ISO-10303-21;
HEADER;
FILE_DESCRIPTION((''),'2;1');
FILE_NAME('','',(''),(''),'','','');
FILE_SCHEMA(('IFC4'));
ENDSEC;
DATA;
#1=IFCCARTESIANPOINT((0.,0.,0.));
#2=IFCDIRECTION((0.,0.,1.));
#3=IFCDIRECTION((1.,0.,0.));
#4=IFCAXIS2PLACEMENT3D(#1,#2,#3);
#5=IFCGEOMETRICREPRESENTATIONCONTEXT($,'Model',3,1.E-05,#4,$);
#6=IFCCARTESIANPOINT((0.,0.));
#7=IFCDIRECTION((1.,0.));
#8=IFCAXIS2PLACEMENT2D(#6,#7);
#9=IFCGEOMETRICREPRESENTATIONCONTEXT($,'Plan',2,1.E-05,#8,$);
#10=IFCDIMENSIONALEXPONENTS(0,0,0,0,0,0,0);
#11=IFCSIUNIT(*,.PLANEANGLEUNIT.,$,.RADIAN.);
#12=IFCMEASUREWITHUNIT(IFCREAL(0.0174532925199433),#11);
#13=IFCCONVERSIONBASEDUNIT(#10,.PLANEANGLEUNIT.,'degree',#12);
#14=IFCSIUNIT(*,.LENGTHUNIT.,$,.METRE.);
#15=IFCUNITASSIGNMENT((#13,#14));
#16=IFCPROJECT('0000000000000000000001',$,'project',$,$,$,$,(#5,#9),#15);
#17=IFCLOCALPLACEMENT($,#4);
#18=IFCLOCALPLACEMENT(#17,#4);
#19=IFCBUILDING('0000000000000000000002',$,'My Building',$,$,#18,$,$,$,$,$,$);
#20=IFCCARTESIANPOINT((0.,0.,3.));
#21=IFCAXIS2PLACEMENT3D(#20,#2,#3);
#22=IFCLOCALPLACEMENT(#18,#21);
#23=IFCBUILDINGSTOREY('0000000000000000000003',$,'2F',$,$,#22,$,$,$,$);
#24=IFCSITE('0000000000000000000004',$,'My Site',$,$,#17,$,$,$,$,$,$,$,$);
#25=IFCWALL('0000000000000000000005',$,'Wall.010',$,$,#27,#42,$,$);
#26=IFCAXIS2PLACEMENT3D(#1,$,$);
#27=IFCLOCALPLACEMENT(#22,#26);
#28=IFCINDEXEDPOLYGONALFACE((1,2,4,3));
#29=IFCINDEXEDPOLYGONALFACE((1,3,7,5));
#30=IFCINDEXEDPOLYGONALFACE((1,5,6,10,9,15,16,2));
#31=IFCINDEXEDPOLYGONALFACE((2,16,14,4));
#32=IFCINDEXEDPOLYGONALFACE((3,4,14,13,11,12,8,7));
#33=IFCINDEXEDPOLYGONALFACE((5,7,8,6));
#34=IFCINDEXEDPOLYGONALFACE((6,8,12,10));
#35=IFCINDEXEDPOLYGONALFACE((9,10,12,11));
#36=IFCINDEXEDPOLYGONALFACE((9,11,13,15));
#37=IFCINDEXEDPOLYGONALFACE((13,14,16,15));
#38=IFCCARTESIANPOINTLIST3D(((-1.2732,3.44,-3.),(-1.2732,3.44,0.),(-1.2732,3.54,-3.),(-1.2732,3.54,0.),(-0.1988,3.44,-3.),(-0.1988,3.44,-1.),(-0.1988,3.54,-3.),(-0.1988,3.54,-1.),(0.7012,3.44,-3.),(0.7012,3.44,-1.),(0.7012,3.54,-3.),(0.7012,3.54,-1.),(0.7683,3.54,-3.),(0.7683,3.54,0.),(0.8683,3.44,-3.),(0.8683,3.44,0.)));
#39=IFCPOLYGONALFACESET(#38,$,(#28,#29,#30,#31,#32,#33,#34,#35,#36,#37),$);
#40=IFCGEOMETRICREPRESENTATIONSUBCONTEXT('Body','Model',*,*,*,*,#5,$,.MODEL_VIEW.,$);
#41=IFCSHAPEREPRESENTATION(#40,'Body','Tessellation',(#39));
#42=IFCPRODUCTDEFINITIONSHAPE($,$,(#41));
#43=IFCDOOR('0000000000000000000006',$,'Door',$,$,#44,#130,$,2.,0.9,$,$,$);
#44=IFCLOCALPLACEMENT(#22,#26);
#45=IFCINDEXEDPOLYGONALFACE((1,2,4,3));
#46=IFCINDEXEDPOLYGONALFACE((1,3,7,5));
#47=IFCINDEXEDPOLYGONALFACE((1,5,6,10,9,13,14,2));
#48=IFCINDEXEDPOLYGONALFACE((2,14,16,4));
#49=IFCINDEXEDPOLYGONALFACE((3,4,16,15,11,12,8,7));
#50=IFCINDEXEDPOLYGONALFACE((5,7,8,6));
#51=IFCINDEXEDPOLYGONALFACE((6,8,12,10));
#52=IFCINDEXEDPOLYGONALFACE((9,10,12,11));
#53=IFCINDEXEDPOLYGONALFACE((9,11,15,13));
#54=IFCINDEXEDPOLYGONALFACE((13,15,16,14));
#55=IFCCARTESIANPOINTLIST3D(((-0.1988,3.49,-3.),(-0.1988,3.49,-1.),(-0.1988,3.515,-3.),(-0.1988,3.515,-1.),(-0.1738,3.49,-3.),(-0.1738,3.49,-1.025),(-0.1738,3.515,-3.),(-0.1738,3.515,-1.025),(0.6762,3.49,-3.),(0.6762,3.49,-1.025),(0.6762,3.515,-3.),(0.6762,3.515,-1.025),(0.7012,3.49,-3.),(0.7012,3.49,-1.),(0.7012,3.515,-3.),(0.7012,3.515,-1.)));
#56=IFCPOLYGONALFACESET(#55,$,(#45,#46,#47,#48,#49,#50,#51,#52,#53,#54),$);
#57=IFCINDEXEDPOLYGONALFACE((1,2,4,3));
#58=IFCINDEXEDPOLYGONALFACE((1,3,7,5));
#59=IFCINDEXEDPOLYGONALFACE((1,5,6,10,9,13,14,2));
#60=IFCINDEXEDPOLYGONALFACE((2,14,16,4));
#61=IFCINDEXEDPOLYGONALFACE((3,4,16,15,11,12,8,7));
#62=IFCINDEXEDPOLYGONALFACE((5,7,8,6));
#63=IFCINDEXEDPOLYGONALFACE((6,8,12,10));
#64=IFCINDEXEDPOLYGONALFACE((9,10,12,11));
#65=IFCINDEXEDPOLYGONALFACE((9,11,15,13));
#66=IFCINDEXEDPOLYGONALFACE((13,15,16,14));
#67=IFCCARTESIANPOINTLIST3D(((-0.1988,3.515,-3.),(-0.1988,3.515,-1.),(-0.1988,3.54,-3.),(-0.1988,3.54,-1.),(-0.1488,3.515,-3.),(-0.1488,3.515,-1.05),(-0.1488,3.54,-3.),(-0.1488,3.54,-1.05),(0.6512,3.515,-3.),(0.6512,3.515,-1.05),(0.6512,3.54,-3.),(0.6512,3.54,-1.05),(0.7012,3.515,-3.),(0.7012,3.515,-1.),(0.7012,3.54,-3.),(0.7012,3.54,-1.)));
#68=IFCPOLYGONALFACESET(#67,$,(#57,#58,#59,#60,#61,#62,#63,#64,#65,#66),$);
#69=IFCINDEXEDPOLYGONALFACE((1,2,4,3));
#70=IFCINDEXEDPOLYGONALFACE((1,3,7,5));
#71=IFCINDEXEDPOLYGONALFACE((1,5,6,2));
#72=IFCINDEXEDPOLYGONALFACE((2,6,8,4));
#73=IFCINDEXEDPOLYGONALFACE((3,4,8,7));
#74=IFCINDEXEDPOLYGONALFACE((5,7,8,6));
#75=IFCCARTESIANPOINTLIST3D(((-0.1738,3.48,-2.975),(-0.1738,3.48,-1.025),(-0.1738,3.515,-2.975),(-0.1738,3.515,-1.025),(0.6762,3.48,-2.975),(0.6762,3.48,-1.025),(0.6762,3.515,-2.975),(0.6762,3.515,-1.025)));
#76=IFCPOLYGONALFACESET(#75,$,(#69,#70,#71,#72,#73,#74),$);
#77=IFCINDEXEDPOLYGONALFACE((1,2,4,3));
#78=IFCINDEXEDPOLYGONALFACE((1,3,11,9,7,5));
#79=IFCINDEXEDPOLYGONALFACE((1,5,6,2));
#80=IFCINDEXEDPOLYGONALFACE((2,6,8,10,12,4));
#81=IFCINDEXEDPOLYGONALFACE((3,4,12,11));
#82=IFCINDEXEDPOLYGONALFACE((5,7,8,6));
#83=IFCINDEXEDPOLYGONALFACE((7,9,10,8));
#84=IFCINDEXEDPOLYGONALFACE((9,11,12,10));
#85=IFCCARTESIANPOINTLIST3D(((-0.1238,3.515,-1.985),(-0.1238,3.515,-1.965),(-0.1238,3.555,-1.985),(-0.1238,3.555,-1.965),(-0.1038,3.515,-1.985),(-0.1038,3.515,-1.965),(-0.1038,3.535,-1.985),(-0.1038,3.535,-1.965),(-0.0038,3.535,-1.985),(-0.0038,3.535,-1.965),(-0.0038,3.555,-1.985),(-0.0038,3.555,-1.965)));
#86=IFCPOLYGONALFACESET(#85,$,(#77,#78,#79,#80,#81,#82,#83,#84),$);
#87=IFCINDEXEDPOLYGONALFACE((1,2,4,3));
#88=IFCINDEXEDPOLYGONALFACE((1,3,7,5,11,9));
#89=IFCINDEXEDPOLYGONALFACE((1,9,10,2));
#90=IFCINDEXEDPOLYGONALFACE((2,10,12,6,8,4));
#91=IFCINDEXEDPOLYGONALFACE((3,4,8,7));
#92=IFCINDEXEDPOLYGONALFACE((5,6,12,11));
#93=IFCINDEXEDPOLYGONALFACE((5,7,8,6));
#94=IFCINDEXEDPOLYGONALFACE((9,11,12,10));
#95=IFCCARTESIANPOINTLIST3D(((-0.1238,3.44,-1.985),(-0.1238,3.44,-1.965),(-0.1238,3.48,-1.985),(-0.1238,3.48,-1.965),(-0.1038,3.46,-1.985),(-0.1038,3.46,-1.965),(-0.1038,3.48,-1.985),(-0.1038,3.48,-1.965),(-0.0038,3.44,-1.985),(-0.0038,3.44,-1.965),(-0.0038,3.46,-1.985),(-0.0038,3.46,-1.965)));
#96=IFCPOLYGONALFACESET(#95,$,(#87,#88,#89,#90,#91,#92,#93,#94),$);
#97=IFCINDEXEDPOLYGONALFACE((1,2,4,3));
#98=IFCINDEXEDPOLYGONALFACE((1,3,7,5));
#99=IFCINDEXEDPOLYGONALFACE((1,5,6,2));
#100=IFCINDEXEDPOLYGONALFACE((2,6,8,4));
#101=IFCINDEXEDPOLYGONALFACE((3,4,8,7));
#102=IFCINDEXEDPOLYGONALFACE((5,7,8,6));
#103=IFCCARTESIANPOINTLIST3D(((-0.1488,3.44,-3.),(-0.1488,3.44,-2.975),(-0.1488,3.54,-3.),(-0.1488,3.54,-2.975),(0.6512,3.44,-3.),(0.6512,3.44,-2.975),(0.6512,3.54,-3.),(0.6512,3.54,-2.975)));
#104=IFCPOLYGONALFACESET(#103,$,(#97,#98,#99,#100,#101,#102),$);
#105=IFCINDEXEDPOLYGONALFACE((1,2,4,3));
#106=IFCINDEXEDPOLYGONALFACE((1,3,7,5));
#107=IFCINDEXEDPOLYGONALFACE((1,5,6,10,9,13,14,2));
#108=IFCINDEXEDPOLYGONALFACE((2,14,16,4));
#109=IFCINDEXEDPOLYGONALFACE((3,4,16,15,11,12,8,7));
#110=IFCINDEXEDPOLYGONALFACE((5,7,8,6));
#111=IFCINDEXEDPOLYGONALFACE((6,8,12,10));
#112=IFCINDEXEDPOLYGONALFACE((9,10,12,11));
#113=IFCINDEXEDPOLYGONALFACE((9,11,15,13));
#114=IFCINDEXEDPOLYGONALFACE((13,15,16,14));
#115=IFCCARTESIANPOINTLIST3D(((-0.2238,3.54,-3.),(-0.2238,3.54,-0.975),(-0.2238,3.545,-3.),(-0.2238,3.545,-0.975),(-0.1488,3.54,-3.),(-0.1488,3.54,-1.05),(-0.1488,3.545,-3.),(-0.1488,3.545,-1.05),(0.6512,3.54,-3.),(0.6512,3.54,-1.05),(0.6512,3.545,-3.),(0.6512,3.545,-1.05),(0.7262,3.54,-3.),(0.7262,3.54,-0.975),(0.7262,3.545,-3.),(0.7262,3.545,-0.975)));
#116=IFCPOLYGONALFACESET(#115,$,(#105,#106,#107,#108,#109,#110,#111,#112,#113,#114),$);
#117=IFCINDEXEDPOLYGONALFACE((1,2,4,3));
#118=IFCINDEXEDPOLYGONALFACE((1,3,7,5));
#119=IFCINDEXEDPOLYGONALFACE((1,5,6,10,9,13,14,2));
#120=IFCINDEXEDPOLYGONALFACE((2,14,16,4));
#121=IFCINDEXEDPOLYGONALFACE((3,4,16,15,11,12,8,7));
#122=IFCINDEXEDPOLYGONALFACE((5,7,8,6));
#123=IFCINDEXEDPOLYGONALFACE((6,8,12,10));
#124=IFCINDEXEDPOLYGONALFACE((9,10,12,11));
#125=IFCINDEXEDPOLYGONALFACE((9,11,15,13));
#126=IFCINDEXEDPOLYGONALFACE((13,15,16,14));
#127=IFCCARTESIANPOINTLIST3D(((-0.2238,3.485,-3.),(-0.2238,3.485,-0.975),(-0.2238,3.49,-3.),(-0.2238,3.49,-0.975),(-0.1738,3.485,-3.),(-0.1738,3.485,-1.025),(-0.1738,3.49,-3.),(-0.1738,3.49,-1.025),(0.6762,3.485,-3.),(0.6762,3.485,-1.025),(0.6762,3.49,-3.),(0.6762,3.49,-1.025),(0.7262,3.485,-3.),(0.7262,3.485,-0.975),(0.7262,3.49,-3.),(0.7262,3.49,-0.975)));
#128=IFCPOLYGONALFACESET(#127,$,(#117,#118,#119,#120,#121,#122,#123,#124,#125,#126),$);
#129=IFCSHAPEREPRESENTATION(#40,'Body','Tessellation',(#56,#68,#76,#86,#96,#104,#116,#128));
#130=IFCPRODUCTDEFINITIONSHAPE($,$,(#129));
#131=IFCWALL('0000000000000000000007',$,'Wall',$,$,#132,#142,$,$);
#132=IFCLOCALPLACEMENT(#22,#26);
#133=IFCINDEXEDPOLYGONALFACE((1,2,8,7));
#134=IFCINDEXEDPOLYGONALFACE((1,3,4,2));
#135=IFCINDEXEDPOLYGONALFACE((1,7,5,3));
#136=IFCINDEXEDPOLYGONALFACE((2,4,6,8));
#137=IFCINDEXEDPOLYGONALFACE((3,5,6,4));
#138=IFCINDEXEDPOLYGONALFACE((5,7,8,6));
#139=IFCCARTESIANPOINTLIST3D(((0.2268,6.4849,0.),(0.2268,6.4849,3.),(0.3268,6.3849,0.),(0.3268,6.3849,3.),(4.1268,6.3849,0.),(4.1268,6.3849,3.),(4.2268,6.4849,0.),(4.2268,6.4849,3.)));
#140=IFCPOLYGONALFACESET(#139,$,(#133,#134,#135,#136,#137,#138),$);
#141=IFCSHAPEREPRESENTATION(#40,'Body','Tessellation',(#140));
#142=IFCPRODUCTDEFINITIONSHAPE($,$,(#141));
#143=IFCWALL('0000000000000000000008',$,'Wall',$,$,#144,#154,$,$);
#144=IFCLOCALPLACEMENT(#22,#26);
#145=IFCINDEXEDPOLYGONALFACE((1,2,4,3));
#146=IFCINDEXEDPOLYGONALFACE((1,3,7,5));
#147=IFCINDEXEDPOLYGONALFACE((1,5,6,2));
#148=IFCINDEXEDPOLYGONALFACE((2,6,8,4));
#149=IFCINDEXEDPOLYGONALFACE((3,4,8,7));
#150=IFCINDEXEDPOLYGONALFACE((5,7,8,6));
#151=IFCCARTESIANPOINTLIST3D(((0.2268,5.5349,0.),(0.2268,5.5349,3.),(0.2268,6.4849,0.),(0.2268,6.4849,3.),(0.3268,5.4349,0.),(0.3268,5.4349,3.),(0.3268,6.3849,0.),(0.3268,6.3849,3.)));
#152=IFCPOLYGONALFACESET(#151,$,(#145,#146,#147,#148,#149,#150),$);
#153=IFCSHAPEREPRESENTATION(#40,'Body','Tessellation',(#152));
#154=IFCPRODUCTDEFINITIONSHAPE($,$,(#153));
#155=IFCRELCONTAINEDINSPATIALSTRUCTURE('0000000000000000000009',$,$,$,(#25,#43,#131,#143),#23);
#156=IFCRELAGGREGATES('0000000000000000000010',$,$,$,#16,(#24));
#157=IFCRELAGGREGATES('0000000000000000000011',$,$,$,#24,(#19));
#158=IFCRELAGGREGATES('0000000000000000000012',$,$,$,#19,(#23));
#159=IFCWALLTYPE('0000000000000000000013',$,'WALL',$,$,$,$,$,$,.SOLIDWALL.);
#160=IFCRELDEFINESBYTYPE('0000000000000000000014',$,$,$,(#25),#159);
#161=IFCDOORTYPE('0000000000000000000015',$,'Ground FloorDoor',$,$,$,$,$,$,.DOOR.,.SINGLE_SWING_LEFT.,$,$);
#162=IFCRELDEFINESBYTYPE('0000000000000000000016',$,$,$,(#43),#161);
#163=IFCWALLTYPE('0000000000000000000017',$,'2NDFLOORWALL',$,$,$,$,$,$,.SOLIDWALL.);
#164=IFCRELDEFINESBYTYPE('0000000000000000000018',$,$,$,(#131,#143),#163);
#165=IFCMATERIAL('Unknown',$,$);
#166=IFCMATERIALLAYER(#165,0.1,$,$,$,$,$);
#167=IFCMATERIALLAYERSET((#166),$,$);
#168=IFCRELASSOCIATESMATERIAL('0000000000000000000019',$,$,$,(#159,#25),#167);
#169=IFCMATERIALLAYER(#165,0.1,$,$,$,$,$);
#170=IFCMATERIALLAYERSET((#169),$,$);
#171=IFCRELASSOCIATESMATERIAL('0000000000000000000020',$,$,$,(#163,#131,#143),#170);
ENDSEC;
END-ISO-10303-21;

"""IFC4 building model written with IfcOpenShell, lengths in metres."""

from ifc_helpers import new_model, entity, si_unit, converted_unit, frame, origin_with_axes, origin_2d_with_axis, place, context, subcontext, project, spatial, line, indexed_curve, outline, extrude, shape, source, transform, mapped, material, layer, layer_set, layer_usage, type_object, type_shapes, element, fill, save


model = new_model("IFC4")

# Units and contexts
model_context = context("Model", 3, precision=1e-05, world=origin_with_axes())
plan_context = context("Plan", 2, precision=1e-05, world=origin_2d_with_axis())
body_context_1 = subcontext(model_context, "Body", "Model", "MODEL_VIEW")
body_context_2 = subcontext(plan_context, "Body", "Plan", "PLAN_VIEW")
ifc_project = project(units=[converted_unit("PLANEANGLEUNIT", "degree", entity("IfcReal", 0.0174532925199433), si_unit("PLANEANGLEUNIT", "RADIAN"), dimensions=[0, 0, 0, 0, 0, 0, 0]), si_unit("LENGTHUNIT", "METRE")], contexts=[model_context, plan_context])

# Site, building, storey
site_placement = place(None, origin_with_axes())
site = spatial("IfcSite", under=ifc_project, at=site_placement, Name="My Site")
building_placement = place(site_placement, origin_with_axes())
building = spatial("IfcBuilding", under=site, at=building_placement, Name="My Building")
storey_placement = place(building_placement, frame((0.0, 0.0, 3.0), z_axis=(0.0, 0.0, 1.0), x_axis=(1.0, 0.0, 0.0)))
storey = spatial("IfcBuildingStorey", under=building, at=storey_placement, Name="2F")

# Shared definitions
ifc_material = material(Name="Unknown")

# Shared definitions
ifc_layer_1 = layer(ifc_material, 0.1)
ifc_layer_set_1 = layer_set([ifc_layer_1])
wall_type_1 = type_object("IfcWallType", Name="WALL", PredefinedType="SOLIDWALL", material=ifc_layer_set_1)

# Shared definitions
shared_shape_1 = source(origin_with_axes(), body_context_1, "Body", "SweptSolid", [
    extrude(outline(indexed_curve([(0.0, 0.0), (0.9, 0.0), (0.9, 2.0), (0.0, 2.0)], segments=[line(1, 2, 3, 4, 1)])), frame((0.0, -0.6, 0.0), z_axis=(0.0, -1.0, 0.0), x_axis=(1.0, 0.0, 0.0)), (0.0, 0.0, -1.0), 1.2),
])
door_type_1 = type_object("IfcDoorType", Name="Ground FloorDoor", OperationType="SINGLE_SWING_LEFT", PredefinedType="DOOR")
shared_shape_2 = source(origin_with_axes(), body_context_1, "Body", "SweptSolid", [
    extrude(outline(indexed_curve([(0.0, 0.0), (0.0, 2.0), (0.9, 2.0), (0.9, 0.0), (0.875, 0.0), (0.875, 1.975), (0.025, 1.975), (0.025, 0.0)], segments=[line(1, 2, 3, 4, 5, 6, 7, 8, 1)])), frame((0.0, 0.025, 0.0), z_axis=(0.0, -1.0, 0.0), x_axis=(1.0, 0.0, 0.0)), (0.0, 0.0, -1.0), 0.025),
    extrude(outline(indexed_curve([(0.0, 0.0), (0.0, 2.0), (0.9, 2.0), (0.9, 0.0), (0.85, 0.0), (0.85, 1.95), (0.05, 1.95), (0.05, 0.0)], segments=[line(1, 2, 3, 4, 5, 6, 7, 8, 1)])), frame((0.0, 0.0, 0.0), z_axis=(0.0, -1.0, 0.0), x_axis=(1.0, 0.0, 0.0)), (0.0, 0.0, -1.0), 0.025),
    extrude(outline(indexed_curve([(0.0, 0.0), (0.85, 0.0), (0.85, 0.035), (0.0, 0.035)], segments=[line(1, 2, 3, 4, 1)])), frame((0.025, 0.025, 0.025), z_axis=(0.0, 0.0, 1.0), x_axis=(1.0, 0.0, 0.0)), (0.0, 0.0, 1.0), 1.95),
    extrude(outline(indexed_curve([(0.0, 0.0), (0.0, -0.04), (-0.12, -0.04), (-0.12, -0.02), (-0.02, -0.02), (-0.02, 0.0)], segments=[line(1, 2, 3, 4, 5, 6, 1)])), frame((0.825, 0.025, 1.015), z_axis=(0.0, 0.0, 1.0), x_axis=(1.0, 0.0, 0.0)), (0.0, 0.0, 1.0), 0.02),
    extrude(outline(indexed_curve([(0.0, 0.0), (0.0, 0.04), (-0.12, 0.04), (-0.12, 0.02), (-0.02, 0.02), (-0.02, 0.0)], segments=[line(1, 2, 3, 4, 5, 6, 1)])), frame((0.825, 0.06, 1.015), z_axis=(0.0, 0.0, 1.0), x_axis=(1.0, 0.0, 0.0)), (0.0, 0.0, 1.0), 0.02),
    extrude(outline(indexed_curve([(0.0, 0.0), (0.8, 0.0), (0.8, 0.1), (0.0, 0.1)], segments=[line(1, 2, 3, 4, 1)])), frame((0.05, 0.0, 0.0), z_axis=(0.0, 0.0, 1.0), x_axis=(1.0, 0.0, 0.0)), (0.0, 0.0, 1.0), 0.025),
    extrude(outline(indexed_curve([(0.0, 0.0), (0.0, 2.025), (0.95, 2.025), (0.95, 0.0), (0.875, 0.0), (0.875, 1.95), (0.075, 1.95), (0.075, 0.0)], segments=[line(1, 2, 3, 4, 5, 6, 7, 8, 1)])), frame((-0.025, -0.005, 0.0), z_axis=(0.0, -1.0, 0.0), x_axis=(1.0, 0.0, 0.0)), (0.0, 0.0, -1.0), 0.005),
    extrude(outline(indexed_curve([(0.0, 0.0), (0.0, 2.025), (0.95, 2.025), (0.95, 0.0), (0.9, 0.0), (0.9, 1.975), (0.05, 1.975), (0.05, 0.0)], segments=[line(1, 2, 3, 4, 5, 6, 7, 8, 1)])), frame((-0.025, 0.05, 0.0), z_axis=(0.0, -1.0, 0.0), x_axis=(1.0, 0.0, 0.0)), (0.0, 0.0, -1.0), 0.005),
])
shared_shape_3 = source(origin_with_axes(), body_context_2, "Body", "Curve2D", [
    entity("IfcIndexedPolyCurve", entity("IfcCartesianPointList2D", [[0.0, 0.0], [0.0, 0.05], [0.025, 0.05], [0.025, 0.025], [0.05, 0.025], [0.05, 0.0]]), [entity("IfcLineIndex", [1, 2, 3, 4, 5, 6, 1])]),
    entity("IfcIndexedPolyCurve", entity("IfcCartesianPointList2D", [[0.9, 0.0], [0.9, 0.05], [0.875, 0.05], [0.875, 0.025], [0.85, 0.025], [0.85, 0.0]]), [entity("IfcLineIndex", [1, 2, 3, 4, 5, 6, 1])]),
    entity("IfcTrimmedCurve", entity("IfcEllipse", entity("IfcAxis2Placement2D", entity("IfcCartesianPoint", [0.06, 0.05]), entity("IfcDirection", [1.0, 0.0])), 0.815, 0.85), [entity("IfcCartesianPoint", [0.875, 0.05])], [entity("IfcCartesianPoint", [0.06, 0.9])], True, "CARTESIAN"),
    entity("IfcIndexedPolyCurve", entity("IfcCartesianPointList2D", [[0.025, 0.05], [0.06, 0.05], [0.06, 0.9], [0.025, 0.9]]), [entity("IfcLineIndex", [1, 2, 3, 4, 1])]),
])
type_shapes(door_type_1, [shared_shape_2, shared_shape_3])

# Wall, opening, door
ifc_layer_usage_1 = layer_usage(ifc_layer_set_1, "AXIS2", "POSITIVE", 0.0)
wall_1_placement = place(storey_placement, frame((0.7683, 3.54, -3.0), z_axis=(0.0, 0.0, 1.0), x_axis=(-1.0, 0.0, 0.0)))
wall_1 = element("IfcWall", 1, at=wall_1_placement, inside=storey, type_object=wall_type_1, material=ifc_layer_usage_1, Name="Wall.010", context=body_context_1, shape_type="SweptSolid", body=[
    extrude(outline(indexed_curve([(0.0, 0.0), (-0.1, 0.1), (2.0415, 0.1), (2.0415, 0.0)], segments=[line(1, 2, 3, 4, 1)])), origin_with_axes(), (0.0, 0.0, 1.0), 3.0),
])
opening_1_placement = place(wall_1_placement, frame((0.0671, 0.0, 0.0), z_axis=(0.0, 0.0, 1.0), x_axis=(1.0, 0.0, 0.0)))
opening_1 = element("IfcOpeningElement", 2, at=opening_1_placement, cuts=wall_1, PredefinedType="OPENING", context=body_context_1, shape_type="MappedRepresentation", body=[
    mapped(shared_shape_1, transform((0.0, 0.0, 0.0), x_axis=(1.0, 0.0, 0.0), y_axis=(0.0, 1.0, 0.0), z_axis=(0.0, 0.0, 1.0), scale=1.0)),
])
door_1_placement = place(opening_1_placement, frame((0.0, 0.0, 0.0), z_axis=(0.0, 0.0, 1.0), x_axis=(1.0, 0.0, 0.0)))
door_1 = element("IfcDoor", 3, at=door_1_placement, inside=storey, type_object=door_type_1, Name="Door", OverallHeight=2.0, OverallWidth=0.9, shapes=[
    shape(body_context_1, "Body", "MappedRepresentation", [mapped(shared_shape_2, transform((0.0, 0.0, 0.0), x_axis=(1.0, 0.0, 0.0), y_axis=(0.0, 1.0, 0.0), z_axis=(0.0, 0.0, 1.0), scale=1.0))]),
    shape(body_context_2, "Body", "MappedRepresentation", [mapped(shared_shape_3, transform((0.0, 0.0, 0.0), x_axis=(1.0, 0.0, 0.0), y_axis=(0.0, 1.0, 0.0), z_axis=(0.0, 0.0, 1.0), scale=1.0))]),
])
fill(opening_1, door_1)

# Walls
ifc_layer_2 = layer(ifc_material, 0.1)
ifc_layer_set_2 = layer_set([ifc_layer_2])
ifc_layer_usage_2 = layer_usage(ifc_layer_set_2, "AXIS2", "POSITIVE", 0.0)
wall_type_2 = type_object("IfcWallType", Name="2NDFLOORWALL", PredefinedType="SOLIDWALL", material=ifc_layer_set_2)
wall_2_placement = place(storey_placement, frame((4.2268, 6.4849, 0.0), z_axis=(0.0, 0.0, 1.0), x_axis=(-1.0, 0.0, 0.0)))
element("IfcWall", 4, at=wall_2_placement, inside=storey, type_object=wall_type_2, material=ifc_layer_usage_2, Name="Wall", context=body_context_1, shape_type="SweptSolid", body=[
    extrude(outline(indexed_curve([(0.0, 0.0), (0.1, 0.1), (3.9, 0.1), (4.0, 0.0)], segments=[line(1, 2, 3, 4, 1)])), origin_with_axes(), (0.0, 0.0, 1.0), 3.0),
])
ifc_layer_usage_3 = layer_usage(ifc_layer_set_2, "AXIS2", "POSITIVE", 0.0)
wall_3_placement = place(storey_placement, frame((0.2268, 6.4849, 0.0), z_axis=(0.0, 0.0, 1.0), x_axis=(0.0, -1.0, 0.0)))
element("IfcWall", 5, at=wall_3_placement, inside=storey, type_object=wall_type_2, material=ifc_layer_usage_3, Name="Wall", context=body_context_1, shape_type="SweptSolid", body=[
    extrude(outline(indexed_curve([(0.0, 0.0), (0.1, 0.1), (1.05, 0.1), (0.95, 0.0)], segments=[line(1, 2, 3, 4, 1)])), origin_with_axes(), (0.0, 0.0, 1.0), 3.0),
])

save(model, "model.ifc")
